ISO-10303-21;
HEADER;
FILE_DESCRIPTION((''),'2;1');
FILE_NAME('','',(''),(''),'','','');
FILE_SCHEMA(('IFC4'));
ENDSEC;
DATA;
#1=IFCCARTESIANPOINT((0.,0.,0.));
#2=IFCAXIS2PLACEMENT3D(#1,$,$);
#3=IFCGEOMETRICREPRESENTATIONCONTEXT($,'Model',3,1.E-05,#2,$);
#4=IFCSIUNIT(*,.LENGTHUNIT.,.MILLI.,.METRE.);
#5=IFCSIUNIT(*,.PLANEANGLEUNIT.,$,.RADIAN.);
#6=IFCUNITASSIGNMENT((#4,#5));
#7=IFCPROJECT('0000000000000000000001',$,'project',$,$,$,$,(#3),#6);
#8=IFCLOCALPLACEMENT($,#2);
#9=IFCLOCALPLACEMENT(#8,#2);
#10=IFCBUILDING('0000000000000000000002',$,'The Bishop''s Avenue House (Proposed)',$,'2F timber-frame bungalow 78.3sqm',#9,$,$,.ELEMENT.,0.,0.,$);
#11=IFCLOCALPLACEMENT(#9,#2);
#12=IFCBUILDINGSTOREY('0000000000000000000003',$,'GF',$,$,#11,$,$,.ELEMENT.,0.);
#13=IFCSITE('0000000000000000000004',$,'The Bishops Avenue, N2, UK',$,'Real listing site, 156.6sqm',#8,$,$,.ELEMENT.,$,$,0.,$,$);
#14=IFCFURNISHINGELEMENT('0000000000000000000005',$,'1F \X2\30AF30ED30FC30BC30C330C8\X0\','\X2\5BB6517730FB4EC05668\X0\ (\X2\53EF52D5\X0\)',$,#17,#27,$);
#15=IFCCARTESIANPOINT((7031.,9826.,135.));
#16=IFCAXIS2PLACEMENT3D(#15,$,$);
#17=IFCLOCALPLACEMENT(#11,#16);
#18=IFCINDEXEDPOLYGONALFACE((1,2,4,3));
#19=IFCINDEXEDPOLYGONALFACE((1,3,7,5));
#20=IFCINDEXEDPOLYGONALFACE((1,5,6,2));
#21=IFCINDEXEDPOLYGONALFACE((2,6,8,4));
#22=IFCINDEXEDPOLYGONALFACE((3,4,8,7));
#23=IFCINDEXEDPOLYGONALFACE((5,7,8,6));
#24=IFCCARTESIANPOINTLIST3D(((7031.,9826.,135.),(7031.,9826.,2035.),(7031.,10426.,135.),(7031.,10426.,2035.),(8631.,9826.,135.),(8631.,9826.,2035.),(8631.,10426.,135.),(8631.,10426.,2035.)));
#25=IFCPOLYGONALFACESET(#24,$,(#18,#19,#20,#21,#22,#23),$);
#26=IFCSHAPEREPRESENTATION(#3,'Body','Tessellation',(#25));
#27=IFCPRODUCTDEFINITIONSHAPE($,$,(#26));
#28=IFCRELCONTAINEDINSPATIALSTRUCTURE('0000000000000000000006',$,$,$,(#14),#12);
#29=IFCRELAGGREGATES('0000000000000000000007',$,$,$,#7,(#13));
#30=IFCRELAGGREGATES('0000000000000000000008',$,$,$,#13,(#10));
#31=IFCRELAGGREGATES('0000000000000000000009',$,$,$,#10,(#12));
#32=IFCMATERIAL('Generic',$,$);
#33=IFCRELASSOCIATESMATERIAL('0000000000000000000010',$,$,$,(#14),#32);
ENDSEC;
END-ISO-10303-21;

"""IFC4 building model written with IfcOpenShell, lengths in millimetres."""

from ifc_helpers import new_model, si_unit, frame, frame_2d, origin, place, context, project, spatial, rectangle, extrude, material, element, save


model = new_model("IFC4")

# Units and contexts
model_context = context("Model", 3, precision=1e-05, world=origin())
ifc_project = project(units=[si_unit("LENGTHUNIT", "METRE", prefix="MILLI"), si_unit("PLANEANGLEUNIT", "RADIAN")], contexts=[model_context])

# Site, building, storey
site_placement = place(None, origin())
site = spatial("IfcSite", under=ifc_project, at=site_placement, Name="The Bishops Avenue, N2, UK", ObjectType="Real listing site, 156.6sqm", CompositionType="ELEMENT", RefElevation=0.0)
building_placement = place(site_placement, origin())
building = spatial("IfcBuilding", under=site, at=building_placement, Name="The Bishop's Avenue House (Proposed)", ObjectType="2F timber-frame bungalow 78.3sqm", CompositionType="ELEMENT", ElevationOfRefHeight=0.0, ElevationOfTerrain=0.0)
storey_placement = place(building_placement, origin())
storey = spatial("IfcBuildingStorey", under=building, at=storey_placement, Name="GF", CompositionType="ELEMENT", Elevation=0.0)

# Shared definitions
ifc_material_1 = material(Name="Generic")

# Furnishing element
furnishing_placement = place(storey_placement, frame((7031.0, 9826.0, 135.0)))
element("IfcFurnishingElement", 1, at=furnishing_placement, inside=storey, material=ifc_material_1, Name="1F クローゼット", Description="家具・什器 (可動)", context=model_context, shape_type="SweptSolid", body=[
    extrude(rectangle(XDim=1600.0, YDim=600.0, at=frame_2d((800.0, 300.0))), frame((7031.0, 9826.0, 135.0)), (0.0, 0.0, 1.0), 1900.0),
])

save(model, "model.ifc")
